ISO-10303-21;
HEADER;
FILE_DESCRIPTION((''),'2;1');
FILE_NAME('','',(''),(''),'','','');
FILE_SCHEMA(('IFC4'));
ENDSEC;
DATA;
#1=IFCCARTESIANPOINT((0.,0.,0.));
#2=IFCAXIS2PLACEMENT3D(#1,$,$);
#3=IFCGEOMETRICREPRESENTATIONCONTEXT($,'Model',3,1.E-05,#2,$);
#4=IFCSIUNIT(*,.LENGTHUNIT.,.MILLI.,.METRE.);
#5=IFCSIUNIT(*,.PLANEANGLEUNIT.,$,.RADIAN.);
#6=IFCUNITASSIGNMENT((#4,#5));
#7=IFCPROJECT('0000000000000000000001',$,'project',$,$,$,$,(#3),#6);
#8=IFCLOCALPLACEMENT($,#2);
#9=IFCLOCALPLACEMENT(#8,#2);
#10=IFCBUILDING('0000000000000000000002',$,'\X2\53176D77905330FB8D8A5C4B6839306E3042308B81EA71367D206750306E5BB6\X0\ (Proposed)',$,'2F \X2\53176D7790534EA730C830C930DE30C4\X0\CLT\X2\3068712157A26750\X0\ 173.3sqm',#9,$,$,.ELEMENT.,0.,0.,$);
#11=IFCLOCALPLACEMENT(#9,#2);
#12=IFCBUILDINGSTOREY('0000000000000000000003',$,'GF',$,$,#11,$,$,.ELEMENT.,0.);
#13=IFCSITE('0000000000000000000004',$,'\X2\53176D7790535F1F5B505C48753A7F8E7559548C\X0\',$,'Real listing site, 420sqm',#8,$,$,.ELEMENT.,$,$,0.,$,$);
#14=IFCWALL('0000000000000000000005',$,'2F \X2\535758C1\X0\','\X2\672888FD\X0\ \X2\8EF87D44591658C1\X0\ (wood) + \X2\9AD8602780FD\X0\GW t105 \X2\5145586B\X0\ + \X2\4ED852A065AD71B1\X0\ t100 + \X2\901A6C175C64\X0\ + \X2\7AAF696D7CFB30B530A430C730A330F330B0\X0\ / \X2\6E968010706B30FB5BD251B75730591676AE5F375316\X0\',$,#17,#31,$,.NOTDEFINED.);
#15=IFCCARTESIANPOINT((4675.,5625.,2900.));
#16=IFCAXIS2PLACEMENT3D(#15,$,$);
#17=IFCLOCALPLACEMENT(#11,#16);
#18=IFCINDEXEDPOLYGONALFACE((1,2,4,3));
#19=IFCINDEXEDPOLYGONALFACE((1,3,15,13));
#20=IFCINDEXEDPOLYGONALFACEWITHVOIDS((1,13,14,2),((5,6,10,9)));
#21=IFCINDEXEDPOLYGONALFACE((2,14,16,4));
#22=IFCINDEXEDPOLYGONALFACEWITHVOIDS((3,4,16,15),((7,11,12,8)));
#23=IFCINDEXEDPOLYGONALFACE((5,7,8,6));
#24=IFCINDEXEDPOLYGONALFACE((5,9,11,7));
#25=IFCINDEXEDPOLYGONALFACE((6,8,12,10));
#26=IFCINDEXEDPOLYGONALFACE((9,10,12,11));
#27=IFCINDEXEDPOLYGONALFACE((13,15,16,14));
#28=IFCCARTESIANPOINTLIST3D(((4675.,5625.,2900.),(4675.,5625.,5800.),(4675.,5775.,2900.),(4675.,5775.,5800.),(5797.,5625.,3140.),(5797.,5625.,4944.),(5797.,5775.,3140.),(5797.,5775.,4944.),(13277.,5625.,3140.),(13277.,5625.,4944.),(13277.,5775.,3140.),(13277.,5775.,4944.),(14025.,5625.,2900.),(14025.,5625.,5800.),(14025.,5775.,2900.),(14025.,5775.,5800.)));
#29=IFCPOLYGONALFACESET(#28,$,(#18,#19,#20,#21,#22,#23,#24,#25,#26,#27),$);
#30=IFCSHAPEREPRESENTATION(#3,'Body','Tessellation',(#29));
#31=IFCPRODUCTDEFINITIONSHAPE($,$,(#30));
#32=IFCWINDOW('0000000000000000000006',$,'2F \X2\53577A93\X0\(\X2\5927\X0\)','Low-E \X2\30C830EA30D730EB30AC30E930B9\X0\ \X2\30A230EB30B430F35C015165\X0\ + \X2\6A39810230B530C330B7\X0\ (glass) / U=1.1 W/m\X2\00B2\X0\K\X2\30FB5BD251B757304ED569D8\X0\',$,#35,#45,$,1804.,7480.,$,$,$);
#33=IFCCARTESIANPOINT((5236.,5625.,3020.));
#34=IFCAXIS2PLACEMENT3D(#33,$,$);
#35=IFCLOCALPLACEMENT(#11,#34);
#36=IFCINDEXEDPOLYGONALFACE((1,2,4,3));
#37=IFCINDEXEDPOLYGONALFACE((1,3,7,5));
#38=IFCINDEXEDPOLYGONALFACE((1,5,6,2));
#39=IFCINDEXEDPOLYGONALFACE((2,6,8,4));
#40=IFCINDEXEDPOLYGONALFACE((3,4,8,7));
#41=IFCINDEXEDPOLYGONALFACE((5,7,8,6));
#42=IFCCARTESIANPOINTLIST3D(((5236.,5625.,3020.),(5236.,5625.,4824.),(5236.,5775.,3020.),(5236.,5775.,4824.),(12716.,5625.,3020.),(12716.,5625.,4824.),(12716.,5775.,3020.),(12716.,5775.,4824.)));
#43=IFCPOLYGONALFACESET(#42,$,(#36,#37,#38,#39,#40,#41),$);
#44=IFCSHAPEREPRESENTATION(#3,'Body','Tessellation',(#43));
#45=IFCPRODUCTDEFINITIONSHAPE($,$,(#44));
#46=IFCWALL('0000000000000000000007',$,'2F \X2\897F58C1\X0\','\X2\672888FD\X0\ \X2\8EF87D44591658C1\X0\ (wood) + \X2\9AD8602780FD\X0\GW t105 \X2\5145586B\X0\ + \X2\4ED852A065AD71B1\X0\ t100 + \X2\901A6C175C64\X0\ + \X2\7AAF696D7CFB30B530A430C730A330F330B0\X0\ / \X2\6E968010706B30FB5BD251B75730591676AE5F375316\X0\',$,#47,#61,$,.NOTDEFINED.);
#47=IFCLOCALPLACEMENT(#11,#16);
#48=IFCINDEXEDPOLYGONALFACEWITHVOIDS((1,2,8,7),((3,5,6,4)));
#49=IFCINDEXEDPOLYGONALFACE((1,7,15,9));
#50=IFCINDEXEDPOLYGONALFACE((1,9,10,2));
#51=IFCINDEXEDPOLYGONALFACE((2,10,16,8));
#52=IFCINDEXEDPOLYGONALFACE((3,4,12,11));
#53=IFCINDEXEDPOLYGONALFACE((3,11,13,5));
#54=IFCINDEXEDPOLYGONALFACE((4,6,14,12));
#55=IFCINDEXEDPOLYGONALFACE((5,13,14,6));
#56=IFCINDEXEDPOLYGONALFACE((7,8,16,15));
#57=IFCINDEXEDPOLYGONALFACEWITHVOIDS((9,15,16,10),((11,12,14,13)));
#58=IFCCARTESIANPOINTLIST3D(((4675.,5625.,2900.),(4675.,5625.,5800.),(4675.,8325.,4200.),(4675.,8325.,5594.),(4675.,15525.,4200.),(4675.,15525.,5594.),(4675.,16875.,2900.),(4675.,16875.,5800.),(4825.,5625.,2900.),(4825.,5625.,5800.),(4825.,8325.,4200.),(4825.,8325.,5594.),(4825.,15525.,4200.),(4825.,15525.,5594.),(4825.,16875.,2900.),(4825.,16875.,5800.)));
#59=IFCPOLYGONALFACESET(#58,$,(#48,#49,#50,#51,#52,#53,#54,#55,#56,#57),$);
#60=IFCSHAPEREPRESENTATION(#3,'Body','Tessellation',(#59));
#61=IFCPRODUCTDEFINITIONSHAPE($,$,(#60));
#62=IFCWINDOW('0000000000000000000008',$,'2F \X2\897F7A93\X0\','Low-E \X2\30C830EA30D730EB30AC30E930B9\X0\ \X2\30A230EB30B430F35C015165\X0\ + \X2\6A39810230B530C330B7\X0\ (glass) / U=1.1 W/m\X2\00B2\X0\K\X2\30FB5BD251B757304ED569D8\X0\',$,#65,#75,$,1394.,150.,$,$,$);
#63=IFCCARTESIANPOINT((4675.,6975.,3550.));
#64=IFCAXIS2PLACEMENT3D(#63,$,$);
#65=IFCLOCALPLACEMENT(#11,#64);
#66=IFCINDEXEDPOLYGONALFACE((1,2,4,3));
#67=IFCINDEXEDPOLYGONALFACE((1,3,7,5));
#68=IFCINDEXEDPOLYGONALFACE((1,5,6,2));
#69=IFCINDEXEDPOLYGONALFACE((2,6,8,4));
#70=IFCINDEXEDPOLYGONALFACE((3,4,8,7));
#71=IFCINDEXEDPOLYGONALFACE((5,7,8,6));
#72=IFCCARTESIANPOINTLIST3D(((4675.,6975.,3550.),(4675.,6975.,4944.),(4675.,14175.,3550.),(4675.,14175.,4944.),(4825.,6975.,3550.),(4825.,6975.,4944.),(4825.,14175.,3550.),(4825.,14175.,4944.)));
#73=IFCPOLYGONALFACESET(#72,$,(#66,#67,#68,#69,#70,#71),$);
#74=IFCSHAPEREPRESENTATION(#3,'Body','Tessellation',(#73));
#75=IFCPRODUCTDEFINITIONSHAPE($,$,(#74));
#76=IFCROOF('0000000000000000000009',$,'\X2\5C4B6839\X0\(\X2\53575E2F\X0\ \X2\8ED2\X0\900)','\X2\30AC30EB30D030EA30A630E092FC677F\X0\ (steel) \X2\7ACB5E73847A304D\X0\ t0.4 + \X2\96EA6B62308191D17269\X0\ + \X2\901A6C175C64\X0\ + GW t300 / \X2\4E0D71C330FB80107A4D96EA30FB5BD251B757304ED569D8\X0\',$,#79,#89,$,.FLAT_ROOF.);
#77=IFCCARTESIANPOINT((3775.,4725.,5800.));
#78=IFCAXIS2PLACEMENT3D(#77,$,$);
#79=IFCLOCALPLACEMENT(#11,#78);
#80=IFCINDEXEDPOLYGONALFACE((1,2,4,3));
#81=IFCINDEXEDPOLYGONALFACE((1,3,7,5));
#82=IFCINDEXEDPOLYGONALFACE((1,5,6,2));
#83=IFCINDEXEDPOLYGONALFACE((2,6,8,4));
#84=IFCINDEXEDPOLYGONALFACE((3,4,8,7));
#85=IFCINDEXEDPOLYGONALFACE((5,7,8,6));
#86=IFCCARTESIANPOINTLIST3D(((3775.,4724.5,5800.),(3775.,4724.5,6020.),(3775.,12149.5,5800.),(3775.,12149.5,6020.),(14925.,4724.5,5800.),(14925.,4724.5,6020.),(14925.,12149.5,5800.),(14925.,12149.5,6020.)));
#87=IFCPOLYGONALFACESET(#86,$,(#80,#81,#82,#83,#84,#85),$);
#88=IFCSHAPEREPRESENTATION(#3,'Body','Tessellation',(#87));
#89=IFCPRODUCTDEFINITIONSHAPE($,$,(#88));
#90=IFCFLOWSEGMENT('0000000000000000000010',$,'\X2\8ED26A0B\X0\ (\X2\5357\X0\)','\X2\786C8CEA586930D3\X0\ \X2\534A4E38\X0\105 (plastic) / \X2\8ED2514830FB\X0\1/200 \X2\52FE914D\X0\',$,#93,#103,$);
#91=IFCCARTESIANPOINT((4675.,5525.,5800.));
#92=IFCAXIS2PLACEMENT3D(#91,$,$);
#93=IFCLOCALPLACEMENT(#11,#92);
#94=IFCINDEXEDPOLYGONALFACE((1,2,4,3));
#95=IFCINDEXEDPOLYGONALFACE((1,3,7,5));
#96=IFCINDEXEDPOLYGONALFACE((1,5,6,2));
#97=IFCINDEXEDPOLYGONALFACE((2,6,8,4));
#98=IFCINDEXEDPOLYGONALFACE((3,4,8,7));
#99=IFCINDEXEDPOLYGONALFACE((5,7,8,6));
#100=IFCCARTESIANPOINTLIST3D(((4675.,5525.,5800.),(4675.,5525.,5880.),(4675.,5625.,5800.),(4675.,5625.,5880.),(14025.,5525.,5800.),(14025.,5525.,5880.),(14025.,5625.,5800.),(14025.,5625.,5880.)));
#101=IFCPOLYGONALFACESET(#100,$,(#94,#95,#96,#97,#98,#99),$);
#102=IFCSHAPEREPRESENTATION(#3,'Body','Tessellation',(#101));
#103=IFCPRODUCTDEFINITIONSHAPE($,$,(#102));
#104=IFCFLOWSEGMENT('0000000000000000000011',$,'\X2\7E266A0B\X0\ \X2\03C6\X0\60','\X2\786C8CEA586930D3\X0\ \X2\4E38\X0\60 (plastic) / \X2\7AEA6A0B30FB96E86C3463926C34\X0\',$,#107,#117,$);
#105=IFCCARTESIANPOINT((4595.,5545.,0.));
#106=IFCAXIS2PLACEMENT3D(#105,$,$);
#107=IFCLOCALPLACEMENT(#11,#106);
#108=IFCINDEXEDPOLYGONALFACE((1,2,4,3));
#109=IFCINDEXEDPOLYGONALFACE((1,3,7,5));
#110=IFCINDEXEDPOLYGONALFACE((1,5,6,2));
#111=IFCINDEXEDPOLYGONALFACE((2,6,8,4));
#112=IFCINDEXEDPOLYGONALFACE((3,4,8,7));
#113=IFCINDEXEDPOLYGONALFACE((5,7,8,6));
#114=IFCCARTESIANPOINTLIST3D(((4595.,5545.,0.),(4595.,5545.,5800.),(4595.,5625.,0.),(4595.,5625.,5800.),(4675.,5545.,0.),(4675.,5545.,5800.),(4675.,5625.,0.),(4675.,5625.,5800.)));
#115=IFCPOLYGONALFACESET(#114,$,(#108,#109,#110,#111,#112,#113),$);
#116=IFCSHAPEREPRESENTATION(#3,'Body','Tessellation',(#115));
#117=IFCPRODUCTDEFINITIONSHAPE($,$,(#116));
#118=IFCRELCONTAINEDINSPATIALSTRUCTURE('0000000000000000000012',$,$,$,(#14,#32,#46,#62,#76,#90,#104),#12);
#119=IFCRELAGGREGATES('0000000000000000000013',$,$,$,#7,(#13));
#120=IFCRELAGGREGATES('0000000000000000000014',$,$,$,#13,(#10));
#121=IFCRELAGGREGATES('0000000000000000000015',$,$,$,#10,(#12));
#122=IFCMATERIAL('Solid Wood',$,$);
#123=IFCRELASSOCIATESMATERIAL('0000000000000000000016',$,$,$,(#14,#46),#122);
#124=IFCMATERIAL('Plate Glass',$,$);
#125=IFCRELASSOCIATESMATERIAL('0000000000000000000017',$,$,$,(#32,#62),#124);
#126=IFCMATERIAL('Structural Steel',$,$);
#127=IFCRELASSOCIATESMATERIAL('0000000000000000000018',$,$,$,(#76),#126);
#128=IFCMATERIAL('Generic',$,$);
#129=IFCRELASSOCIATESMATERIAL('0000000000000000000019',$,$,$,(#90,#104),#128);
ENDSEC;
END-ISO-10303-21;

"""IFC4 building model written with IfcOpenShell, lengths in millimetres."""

from ifc_helpers import new_model, si_unit, frame, frame_2d, origin, place, context, project, spatial, rectangle, extrude, material, element, fill, save


model = new_model("IFC4")

# Units and contexts
model_context = context("Model", 3, precision=1e-05, world=origin())
ifc_project = project(units=[si_unit("LENGTHUNIT", "METRE", prefix="MILLI"), si_unit("PLANEANGLEUNIT", "RADIAN")], contexts=[model_context])

# Site, building, storey
site_placement = place(None, origin())
site = spatial("IfcSite", under=ifc_project, at=site_placement, Name="北海道弟子屈町美留和", ObjectType="Real listing site, 420sqm", CompositionType="ELEMENT", RefElevation=0.0)
building_placement = place(site_placement, origin())
building = spatial("IfcBuilding", under=site, at=building_placement, Name="北海道・越屋根のある自然素材の家 (Proposed)", ObjectType="2F 北海道产トドマツCLTと無垢材 173.3sqm", CompositionType="ELEMENT", ElevationOfRefHeight=0.0, ElevationOfTerrain=0.0)
storey_placement = place(building_placement, origin())
storey = spatial("IfcBuildingStorey", under=building, at=storey_placement, Name="GF", CompositionType="ELEMENT", Elevation=0.0)

# Shared definitions
ifc_material_1 = material(Name="Solid Wood")

# Shared definitions
ifc_material_2 = material(Name="Plate Glass")

# Walls, openings, windows
wall_1_placement = place(storey_placement, frame((4675.0, 5625.0, 2900.0)))
wall_1 = element("IfcWall", 1, at=wall_1_placement, inside=storey, material=ifc_material_1, Name="2F 南壁", Description="木製 軸組外壁 (wood) + 高性能GW t105 充填 + 付加断熱 t100 + 通気層 + 窯業系サイディング / 準耐火・寒冷地外皮強化", PredefinedType="NOTDEFINED", context=model_context, shape_type="SweptSolid", body=[
    extrude(rectangle(XDim=9350.0, YDim=150.0, at=frame_2d((4675.0, 75.0))), frame((4675.0, 5625.0, 2900.0)), (0.0, 0.0, 1.0), 2900.0),
])
opening_1_placement = place(storey_placement, frame((5236.0, 5625.0, 3020.0)))
opening_1 = element("IfcOpeningElement", 2, at=opening_1_placement, cuts=wall_1, PredefinedType="NOTDEFINED", context=model_context, shape_type="SweptSolid", body=[
    extrude(rectangle(XDim=7480.0, YDim=150.0, at=frame_2d((3740.0, 75.0))), frame((5236.0, 5625.0, 3020.0)), (0.0, 0.0, 1.0), 1804.0),
])
window_1_placement = place(storey_placement, frame((5236.0, 5625.0, 3020.0)))
window_1 = element("IfcWindow", 3, at=window_1_placement, inside=storey, material=ifc_material_2, Name="2F 南窓(大)", Description="Low-E トリプルガラス アルゴン封入 + 樹脂サッシ (glass) / U=1.1 W/m²K・寒冷地仕様", OverallHeight=1804.0, OverallWidth=7480.0, context=model_context, shape_type="SweptSolid", body=[
    extrude(rectangle(XDim=7480.0, YDim=150.0, at=frame_2d((3740.0, 75.0))), frame((5236.0, 5625.0, 3020.0)), (0.0, 0.0, 1.0), 1804.0),
])
fill(opening_1, window_1)
wall_2_placement = place(storey_placement, frame((4675.0, 5625.0, 2900.0)))
wall_2 = element("IfcWall", 4, at=wall_2_placement, inside=storey, material=ifc_material_1, Name="2F 西壁", Description="木製 軸組外壁 (wood) + 高性能GW t105 充填 + 付加断熱 t100 + 通気層 + 窯業系サイディング / 準耐火・寒冷地外皮強化", PredefinedType="NOTDEFINED", context=model_context, shape_type="SweptSolid", body=[
    extrude(rectangle(XDim=150.0, YDim=11250.0, at=frame_2d((75.0, 5625.0))), frame((4675.0, 5625.0, 2900.0)), (0.0, 0.0, 1.0), 2900.0),
])
opening_2_placement = place(storey_placement, frame((4675.0, 6975.0, 3550.0)))
opening_2 = element("IfcOpeningElement", 5, at=opening_2_placement, cuts=wall_2, PredefinedType="NOTDEFINED", context=model_context, shape_type="SweptSolid", body=[
    extrude(rectangle(XDim=150.0, YDim=7200.0, at=frame_2d((75.0, 3600.0))), frame((4675.0, 6975.0, 3550.0)), (0.0, 0.0, 1.0), 1394.0),
])
window_2_placement = place(storey_placement, frame((4675.0, 6975.0, 3550.0)))
window_2 = element("IfcWindow", 6, at=window_2_placement, inside=storey, material=ifc_material_2, Name="2F 西窓", Description="Low-E トリプルガラス アルゴン封入 + 樹脂サッシ (glass) / U=1.1 W/m²K・寒冷地仕様", OverallHeight=1394.0, OverallWidth=150.0, context=model_context, shape_type="SweptSolid", body=[
    extrude(rectangle(XDim=150.0, YDim=7200.0, at=frame_2d((75.0, 3600.0))), frame((4675.0, 6975.0, 3550.0)), (0.0, 0.0, 1.0), 1394.0),
])
fill(opening_2, window_2)

# Roof
ifc_material_3 = material(Name="Structural Steel")
for number, where, name in (
    (7, (3775.0, 4725.0, 5800.0), "屋根(南帯 軒900)"),
):
    element("IfcRoof", number, at=place(storey_placement, frame(where)), inside=storey, material=ifc_material_3, Name=name, Description="ガルバリウム鋼板 (steel) 立平葺き t0.4 + 雪止め金物 + 通気層 + GW t300 / 不燃・耐積雪・寒冷地仕様", PredefinedType="FLAT_ROOF", context=model_context, shape_type="SweptSolid", body=[
        extrude(rectangle(XDim=11150.0, YDim=7425.0, at=frame_2d((5575.0, 3712.0))), frame((3775.0, 4725.0, 5800.0)), (0.0, 0.0, 1.0), 220.0),
    ])

# Flow segments
ifc_material_4 = material(Name="Generic")
flow_segment_1_placement = place(storey_placement, frame((4675.0, 5525.0, 5800.0)))
element("IfcFlowSegment", 8, at=flow_segment_1_placement, inside=storey, material=ifc_material_4, Name="軒樋 (南)", Description="硬質塩ビ 半丸105 (plastic) / 軒先・1/200 勾配", context=model_context, shape_type="SweptSolid", body=[
    extrude(rectangle(XDim=9350.0, YDim=100.0, at=frame_2d((4675.0, 50.0))), frame((4675.0, 5525.0, 5800.0)), (0.0, 0.0, 1.0), 80.0),
])
flow_segment_2_placement = place(storey_placement, frame((4595.0, 5545.0, 0.0)))
element("IfcFlowSegment", 9, at=flow_segment_2_placement, inside=storey, material=ifc_material_4, Name="縦樋 φ60", Description="硬質塩ビ 丸60 (plastic) / 竪樋・雨水排水", context=model_context, shape_type="SweptSolid", body=[
    extrude(rectangle(XDim=80.0, YDim=80.0, at=frame_2d((40.0, 40.0))), frame((4595.0, 5545.0, 0.0)), (0.0, 0.0, 1.0), 5800.0),
])

save(model, "model.ifc")
